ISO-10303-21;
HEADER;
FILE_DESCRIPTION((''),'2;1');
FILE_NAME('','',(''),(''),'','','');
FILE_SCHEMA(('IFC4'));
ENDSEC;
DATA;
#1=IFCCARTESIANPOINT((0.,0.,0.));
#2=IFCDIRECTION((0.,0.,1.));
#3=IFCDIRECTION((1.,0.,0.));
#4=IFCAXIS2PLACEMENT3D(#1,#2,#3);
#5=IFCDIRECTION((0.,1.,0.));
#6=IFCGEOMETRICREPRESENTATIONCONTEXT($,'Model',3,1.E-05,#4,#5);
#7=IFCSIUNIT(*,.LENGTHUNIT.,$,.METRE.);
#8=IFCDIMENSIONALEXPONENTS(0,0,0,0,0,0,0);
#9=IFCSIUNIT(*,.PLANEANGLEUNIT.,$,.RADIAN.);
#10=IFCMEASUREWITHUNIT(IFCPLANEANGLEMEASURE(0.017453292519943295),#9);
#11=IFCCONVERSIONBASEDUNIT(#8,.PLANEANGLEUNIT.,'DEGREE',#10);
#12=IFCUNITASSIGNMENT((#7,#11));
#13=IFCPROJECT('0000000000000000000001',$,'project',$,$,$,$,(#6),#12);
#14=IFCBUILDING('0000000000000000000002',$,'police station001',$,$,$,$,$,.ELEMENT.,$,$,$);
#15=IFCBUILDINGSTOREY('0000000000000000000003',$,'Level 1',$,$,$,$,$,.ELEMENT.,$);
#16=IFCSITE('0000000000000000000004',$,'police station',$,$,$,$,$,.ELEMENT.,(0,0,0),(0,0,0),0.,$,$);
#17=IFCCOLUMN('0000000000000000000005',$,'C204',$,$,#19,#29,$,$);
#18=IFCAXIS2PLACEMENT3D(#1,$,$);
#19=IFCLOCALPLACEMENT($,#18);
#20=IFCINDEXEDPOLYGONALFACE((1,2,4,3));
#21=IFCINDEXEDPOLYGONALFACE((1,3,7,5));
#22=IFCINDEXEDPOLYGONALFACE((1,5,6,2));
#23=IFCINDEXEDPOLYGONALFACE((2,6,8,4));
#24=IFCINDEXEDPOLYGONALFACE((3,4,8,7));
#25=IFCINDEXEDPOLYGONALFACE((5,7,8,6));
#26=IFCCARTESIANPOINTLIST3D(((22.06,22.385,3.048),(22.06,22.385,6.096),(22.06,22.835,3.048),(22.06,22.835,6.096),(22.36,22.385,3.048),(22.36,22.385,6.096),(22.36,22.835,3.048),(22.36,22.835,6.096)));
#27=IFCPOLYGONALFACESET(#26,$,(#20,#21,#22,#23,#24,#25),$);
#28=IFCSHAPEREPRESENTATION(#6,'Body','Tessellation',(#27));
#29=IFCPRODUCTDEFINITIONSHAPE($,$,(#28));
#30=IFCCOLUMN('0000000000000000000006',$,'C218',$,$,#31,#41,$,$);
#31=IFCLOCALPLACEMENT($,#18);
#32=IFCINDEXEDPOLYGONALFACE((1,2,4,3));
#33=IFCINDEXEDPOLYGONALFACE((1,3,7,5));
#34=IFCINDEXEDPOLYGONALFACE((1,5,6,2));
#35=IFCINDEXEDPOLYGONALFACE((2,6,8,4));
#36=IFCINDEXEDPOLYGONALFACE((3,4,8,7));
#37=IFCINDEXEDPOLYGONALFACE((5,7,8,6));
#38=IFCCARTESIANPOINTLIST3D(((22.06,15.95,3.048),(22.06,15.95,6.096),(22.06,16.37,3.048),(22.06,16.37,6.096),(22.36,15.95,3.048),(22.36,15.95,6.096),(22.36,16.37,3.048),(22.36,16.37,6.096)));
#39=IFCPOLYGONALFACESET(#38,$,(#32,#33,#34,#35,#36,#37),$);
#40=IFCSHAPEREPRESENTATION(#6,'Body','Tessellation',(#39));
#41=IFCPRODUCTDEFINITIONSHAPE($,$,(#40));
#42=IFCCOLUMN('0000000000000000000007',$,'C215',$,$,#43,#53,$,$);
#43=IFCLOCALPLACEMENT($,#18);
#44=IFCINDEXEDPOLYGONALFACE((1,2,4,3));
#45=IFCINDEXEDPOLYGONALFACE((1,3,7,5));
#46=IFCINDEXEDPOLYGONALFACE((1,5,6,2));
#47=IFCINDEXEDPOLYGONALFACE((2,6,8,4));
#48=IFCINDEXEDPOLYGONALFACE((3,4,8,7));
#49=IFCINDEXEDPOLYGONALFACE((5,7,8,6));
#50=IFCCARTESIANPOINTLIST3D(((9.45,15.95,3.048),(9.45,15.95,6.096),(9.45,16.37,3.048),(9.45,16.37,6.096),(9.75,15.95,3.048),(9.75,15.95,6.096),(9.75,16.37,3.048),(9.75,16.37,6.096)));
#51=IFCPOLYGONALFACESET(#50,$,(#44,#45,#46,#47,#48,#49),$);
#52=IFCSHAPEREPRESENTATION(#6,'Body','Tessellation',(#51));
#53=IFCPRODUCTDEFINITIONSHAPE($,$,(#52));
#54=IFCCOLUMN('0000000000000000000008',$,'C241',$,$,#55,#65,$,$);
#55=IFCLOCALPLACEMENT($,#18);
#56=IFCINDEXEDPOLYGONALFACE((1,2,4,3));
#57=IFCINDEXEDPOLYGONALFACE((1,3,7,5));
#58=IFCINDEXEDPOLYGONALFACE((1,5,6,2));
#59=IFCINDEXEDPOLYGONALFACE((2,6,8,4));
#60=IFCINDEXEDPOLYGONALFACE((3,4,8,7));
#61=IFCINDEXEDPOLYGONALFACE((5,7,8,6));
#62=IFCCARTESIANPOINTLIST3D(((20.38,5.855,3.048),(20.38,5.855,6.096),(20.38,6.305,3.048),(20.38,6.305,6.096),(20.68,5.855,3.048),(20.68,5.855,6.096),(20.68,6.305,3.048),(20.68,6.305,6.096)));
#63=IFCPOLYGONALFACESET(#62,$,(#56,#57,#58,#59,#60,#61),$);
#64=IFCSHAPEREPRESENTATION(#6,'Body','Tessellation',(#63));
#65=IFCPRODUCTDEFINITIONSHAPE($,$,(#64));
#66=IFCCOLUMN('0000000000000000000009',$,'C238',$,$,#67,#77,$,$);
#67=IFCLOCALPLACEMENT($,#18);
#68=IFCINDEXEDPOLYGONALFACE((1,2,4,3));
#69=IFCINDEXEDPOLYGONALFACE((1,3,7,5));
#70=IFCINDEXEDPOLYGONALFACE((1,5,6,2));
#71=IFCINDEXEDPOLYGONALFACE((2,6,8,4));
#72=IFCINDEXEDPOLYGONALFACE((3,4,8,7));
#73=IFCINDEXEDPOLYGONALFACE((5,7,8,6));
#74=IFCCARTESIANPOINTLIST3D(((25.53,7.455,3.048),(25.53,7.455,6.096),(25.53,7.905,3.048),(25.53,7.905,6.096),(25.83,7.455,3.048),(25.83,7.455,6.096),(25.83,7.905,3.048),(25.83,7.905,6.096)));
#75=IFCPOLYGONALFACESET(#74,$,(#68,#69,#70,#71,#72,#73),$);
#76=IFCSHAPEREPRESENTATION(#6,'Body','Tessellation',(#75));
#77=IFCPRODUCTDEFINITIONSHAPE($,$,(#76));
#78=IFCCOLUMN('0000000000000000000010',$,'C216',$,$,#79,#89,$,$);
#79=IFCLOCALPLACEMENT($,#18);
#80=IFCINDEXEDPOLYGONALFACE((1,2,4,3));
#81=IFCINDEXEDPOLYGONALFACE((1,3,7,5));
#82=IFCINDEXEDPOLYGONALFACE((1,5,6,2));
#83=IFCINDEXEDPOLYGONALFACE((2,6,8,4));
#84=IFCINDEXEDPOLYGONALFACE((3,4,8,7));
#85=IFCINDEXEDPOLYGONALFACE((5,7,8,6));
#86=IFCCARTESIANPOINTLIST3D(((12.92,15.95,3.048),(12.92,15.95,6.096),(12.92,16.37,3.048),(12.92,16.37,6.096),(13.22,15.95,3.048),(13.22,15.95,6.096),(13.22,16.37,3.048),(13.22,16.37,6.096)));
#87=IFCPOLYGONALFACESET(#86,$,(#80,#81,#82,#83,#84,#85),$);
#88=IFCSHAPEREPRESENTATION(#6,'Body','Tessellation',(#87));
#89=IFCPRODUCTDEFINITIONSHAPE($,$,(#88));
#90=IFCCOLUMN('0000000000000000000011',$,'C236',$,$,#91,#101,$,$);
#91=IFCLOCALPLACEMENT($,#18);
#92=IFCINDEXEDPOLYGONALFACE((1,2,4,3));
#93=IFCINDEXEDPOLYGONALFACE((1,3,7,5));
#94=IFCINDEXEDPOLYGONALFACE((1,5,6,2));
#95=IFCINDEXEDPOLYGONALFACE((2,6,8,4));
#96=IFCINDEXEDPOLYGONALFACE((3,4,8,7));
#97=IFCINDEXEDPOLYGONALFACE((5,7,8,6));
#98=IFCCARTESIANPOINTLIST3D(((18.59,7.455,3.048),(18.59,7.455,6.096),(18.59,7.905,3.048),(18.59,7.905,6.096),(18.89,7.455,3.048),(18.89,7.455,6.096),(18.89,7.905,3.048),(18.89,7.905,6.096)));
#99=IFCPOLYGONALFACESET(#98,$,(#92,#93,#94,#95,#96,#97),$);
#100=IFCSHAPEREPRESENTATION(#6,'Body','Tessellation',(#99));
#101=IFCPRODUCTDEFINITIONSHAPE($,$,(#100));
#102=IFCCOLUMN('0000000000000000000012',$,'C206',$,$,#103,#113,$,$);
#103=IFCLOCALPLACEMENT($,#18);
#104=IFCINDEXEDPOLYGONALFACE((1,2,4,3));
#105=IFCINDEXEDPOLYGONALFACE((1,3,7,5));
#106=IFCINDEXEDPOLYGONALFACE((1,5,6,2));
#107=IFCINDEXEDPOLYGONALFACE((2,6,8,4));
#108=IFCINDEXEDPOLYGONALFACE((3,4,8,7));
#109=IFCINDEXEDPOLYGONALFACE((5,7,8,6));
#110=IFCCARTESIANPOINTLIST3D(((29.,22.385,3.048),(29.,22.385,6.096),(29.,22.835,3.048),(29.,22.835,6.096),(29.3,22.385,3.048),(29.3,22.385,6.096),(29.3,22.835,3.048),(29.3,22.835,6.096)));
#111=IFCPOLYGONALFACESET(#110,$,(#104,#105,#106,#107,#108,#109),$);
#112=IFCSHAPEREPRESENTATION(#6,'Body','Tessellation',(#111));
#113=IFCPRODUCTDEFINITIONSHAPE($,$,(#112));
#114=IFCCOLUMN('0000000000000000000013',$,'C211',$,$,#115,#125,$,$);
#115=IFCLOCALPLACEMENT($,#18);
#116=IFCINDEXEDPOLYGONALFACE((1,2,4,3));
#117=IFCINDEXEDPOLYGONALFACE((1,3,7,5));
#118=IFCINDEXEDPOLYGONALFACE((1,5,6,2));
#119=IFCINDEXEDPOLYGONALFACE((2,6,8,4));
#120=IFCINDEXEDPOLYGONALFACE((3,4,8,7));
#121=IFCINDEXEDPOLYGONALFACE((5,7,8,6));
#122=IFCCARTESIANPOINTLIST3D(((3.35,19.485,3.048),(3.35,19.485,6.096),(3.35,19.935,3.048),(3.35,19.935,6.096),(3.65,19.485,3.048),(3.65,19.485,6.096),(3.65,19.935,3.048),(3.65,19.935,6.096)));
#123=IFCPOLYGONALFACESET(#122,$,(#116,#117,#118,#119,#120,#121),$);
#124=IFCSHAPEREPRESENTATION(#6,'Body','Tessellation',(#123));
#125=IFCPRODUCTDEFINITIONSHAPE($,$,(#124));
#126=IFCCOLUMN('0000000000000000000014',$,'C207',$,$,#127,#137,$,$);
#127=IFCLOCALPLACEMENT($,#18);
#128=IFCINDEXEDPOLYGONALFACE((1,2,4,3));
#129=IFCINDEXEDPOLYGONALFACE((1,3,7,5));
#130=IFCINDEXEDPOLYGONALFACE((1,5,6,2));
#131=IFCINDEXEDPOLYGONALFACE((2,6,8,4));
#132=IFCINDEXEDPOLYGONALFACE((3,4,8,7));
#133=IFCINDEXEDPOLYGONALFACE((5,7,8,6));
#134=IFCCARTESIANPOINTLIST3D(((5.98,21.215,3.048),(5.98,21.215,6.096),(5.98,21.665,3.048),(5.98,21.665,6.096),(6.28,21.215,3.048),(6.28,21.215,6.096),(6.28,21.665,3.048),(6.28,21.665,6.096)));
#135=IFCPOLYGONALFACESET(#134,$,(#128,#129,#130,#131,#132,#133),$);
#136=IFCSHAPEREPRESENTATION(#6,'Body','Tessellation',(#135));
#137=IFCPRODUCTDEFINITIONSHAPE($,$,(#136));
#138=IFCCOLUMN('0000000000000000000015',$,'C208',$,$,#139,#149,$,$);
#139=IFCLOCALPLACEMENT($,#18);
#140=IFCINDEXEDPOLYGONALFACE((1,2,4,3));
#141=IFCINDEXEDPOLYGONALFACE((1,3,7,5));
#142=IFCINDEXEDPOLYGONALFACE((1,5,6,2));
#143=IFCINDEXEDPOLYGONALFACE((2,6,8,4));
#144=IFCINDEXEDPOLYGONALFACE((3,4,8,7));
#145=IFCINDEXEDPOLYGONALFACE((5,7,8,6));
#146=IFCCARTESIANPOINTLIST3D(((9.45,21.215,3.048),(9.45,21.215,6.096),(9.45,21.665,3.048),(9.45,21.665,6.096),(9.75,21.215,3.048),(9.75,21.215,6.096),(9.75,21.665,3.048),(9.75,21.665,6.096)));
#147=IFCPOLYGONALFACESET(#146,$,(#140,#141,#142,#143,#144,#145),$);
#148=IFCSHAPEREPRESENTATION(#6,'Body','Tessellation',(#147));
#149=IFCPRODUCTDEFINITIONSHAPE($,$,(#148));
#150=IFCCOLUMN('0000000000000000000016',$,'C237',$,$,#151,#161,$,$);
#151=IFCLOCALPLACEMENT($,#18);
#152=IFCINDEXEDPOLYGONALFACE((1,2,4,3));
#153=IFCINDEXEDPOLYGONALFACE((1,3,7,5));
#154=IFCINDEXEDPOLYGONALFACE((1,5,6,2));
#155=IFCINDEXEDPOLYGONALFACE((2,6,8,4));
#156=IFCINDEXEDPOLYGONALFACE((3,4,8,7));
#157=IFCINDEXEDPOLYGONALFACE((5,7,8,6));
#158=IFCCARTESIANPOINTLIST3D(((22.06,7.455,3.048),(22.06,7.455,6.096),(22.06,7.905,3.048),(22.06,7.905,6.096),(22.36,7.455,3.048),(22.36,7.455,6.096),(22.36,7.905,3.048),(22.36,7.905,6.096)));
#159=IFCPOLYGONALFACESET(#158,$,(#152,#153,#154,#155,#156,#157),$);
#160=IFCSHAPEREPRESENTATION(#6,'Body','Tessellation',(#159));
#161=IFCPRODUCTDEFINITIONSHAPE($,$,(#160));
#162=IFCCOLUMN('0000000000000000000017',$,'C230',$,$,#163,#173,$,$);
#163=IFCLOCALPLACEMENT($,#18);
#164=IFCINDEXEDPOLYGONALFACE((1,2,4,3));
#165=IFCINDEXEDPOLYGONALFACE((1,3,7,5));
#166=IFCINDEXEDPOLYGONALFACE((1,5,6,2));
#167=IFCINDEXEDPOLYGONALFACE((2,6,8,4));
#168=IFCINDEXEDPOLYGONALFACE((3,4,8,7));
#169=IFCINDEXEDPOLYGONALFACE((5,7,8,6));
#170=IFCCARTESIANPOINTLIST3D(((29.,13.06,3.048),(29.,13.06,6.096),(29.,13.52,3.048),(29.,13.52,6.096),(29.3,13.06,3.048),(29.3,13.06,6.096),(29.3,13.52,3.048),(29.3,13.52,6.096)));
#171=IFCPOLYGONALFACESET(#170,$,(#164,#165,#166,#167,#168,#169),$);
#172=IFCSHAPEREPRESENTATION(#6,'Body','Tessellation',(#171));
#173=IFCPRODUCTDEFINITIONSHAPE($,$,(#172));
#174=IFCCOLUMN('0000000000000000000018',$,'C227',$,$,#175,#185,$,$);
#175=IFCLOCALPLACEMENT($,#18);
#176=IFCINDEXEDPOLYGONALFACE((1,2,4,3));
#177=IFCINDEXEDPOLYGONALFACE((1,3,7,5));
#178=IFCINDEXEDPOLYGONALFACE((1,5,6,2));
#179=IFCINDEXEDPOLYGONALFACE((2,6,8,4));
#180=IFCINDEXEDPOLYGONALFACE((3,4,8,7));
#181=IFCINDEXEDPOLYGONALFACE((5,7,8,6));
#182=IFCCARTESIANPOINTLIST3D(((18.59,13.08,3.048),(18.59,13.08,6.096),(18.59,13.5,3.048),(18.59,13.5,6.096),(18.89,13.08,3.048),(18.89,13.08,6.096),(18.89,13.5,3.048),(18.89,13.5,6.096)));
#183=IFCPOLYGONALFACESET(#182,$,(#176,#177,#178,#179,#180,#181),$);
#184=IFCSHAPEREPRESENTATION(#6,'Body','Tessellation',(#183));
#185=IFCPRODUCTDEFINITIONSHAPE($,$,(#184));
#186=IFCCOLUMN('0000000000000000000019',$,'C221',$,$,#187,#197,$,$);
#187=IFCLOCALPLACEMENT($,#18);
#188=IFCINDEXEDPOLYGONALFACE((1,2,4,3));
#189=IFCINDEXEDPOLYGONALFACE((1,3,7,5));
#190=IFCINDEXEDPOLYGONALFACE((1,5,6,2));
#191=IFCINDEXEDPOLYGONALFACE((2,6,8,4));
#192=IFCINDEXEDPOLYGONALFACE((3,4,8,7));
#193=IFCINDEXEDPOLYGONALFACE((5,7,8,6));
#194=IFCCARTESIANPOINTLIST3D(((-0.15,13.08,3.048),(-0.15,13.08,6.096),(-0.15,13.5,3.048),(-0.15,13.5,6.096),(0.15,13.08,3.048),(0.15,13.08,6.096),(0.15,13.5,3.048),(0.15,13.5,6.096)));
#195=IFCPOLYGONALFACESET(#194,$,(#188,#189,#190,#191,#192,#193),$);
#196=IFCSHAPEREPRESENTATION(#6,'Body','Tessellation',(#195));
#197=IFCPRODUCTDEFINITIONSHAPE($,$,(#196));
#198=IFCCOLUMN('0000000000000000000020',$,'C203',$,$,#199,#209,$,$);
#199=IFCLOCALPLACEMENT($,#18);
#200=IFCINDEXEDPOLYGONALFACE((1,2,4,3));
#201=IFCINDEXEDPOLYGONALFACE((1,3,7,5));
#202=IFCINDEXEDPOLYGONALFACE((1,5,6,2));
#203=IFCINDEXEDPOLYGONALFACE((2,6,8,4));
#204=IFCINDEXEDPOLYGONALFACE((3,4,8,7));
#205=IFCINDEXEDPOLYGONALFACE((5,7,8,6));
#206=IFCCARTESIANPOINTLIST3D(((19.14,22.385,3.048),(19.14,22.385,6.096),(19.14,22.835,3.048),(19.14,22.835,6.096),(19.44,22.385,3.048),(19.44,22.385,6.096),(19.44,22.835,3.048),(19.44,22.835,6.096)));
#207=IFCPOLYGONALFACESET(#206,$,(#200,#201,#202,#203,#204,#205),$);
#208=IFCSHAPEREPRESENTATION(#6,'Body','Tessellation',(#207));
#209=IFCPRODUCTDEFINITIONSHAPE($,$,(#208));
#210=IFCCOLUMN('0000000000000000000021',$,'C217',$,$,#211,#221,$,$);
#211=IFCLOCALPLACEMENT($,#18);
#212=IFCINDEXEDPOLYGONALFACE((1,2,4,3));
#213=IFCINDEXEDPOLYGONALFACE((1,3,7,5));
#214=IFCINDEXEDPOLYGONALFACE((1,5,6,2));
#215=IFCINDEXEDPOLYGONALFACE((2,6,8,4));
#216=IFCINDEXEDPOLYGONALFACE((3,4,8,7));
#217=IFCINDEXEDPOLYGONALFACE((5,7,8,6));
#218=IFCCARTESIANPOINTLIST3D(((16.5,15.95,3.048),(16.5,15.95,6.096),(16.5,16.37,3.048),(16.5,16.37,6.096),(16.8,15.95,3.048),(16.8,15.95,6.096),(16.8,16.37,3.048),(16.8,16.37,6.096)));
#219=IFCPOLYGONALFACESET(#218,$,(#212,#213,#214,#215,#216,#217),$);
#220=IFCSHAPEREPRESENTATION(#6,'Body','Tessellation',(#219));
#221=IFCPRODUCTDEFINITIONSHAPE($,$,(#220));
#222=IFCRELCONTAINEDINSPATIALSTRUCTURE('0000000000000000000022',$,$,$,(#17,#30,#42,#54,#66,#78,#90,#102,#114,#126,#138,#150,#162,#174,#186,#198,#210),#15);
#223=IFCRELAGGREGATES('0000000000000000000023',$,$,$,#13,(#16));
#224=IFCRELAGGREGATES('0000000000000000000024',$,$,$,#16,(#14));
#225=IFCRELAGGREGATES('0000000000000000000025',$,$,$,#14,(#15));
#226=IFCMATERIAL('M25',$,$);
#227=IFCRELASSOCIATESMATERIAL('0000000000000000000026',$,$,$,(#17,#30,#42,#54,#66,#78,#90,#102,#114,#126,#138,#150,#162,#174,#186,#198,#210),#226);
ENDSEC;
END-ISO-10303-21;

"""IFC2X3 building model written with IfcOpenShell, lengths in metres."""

from ifc_helpers import new_model, entity, si_unit, converted_unit, direction, frame, frame_2d, origin_with_axes, place, context, project, spatial, rectangle, extrude, material, element, save


model = new_model("IFC2X3")

# Units and contexts
model_context = context("Model", 3, precision=1e-05, world=origin_with_axes(), true_north=direction((0.0, 1.0, 0.0)))
ifc_project = project(units=[si_unit("LENGTHUNIT", "METRE"), converted_unit("PLANEANGLEUNIT", "DEGREE", entity("IfcPlaneAngleMeasure", 0.017453292519943295), si_unit("PLANEANGLEUNIT", "RADIAN"), dimensions=[0, 0, 0, 0, 0, 0, 0])], contexts=[model_context])

# Site, building, storey
site = spatial("IfcSite", under=ifc_project, Name="police station", CompositionType="ELEMENT", RefLatitude=(0, 0, 0), RefLongitude=(0, 0, 0), RefElevation=0.0)
building = spatial("IfcBuilding", under=site, Name="police station001", CompositionType="ELEMENT")
storey = spatial("IfcBuildingStorey", under=building, Name="Level 1", CompositionType="ELEMENT")

# Columns
ifc_material = material(Name="M25")
placement = place(None, origin_with_axes())
element("IfcColumn", 1, at=placement, inside=storey, material=ifc_material, Name="C204", context=model_context, shape_type="SweptSolid", body=[
    extrude(rectangle(XDim=0.3, YDim=0.45, at=frame_2d((0.0, 0.0), x_axis=(1.0, 0.0, 0.0))), frame((22.21, 22.61, 3.048), z_axis=(0.0, 0.0, 1.0), x_axis=(1.0, 0.0, 0.0)), (0.0, 0.0, 1.0), 3.048),
])
element("IfcColumn", 2, at=placement, inside=storey, material=ifc_material, Name="C218", context=model_context, shape_type="SweptSolid", body=[
    extrude(rectangle(XDim=0.3, YDim=0.42, at=frame_2d((0.0, 0.0), x_axis=(1.0, 0.0, 0.0))), frame((22.21, 16.16, 3.048), z_axis=(0.0, 0.0, 1.0), x_axis=(1.0, 0.0, 0.0)), (0.0, 0.0, 1.0), 3.048),
])
element("IfcColumn", 3, at=placement, inside=storey, material=ifc_material, Name="C215", context=model_context, shape_type="SweptSolid", body=[
    extrude(rectangle(XDim=0.3, YDim=0.42, at=frame_2d((0.0, 0.0), x_axis=(1.0, 0.0, 0.0))), frame((9.6, 16.16, 3.048), z_axis=(0.0, 0.0, 1.0), x_axis=(1.0, 0.0, 0.0)), (0.0, 0.0, 1.0), 3.048),
])
element("IfcColumn", 4, at=placement, inside=storey, material=ifc_material, Name="C241", context=model_context, shape_type="SweptSolid", body=[
    extrude(rectangle(XDim=0.3, YDim=0.45, at=frame_2d((0.0, 0.0), x_axis=(1.0, 0.0, 0.0))), frame((20.53, 6.08, 3.048), z_axis=(0.0, 0.0, 1.0), x_axis=(1.0, 0.0, 0.0)), (0.0, 0.0, 1.0), 3.048),
])
element("IfcColumn", 5, at=placement, inside=storey, material=ifc_material, Name="C238", context=model_context, shape_type="SweptSolid", body=[
    extrude(rectangle(XDim=0.3, YDim=0.45, at=frame_2d((0.0, 0.0), x_axis=(1.0, 0.0, 0.0))), frame((25.68, 7.68, 3.048), z_axis=(0.0, 0.0, 1.0), x_axis=(1.0, 0.0, 0.0)), (0.0, 0.0, 1.0), 3.048),
])
element("IfcColumn", 6, at=placement, inside=storey, material=ifc_material, Name="C216", context=model_context, shape_type="SweptSolid", body=[
    extrude(rectangle(XDim=0.3, YDim=0.42, at=frame_2d((0.0, 0.0), x_axis=(1.0, 0.0, 0.0))), frame((13.07, 16.16, 3.048), z_axis=(0.0, 0.0, 1.0), x_axis=(1.0, 0.0, 0.0)), (0.0, 0.0, 1.0), 3.048),
])
element("IfcColumn", 7, at=placement, inside=storey, material=ifc_material, Name="C236", context=model_context, shape_type="SweptSolid", body=[
    extrude(rectangle(XDim=0.3, YDim=0.45, at=frame_2d((0.0, 0.0), x_axis=(1.0, 0.0, 0.0))), frame((18.74, 7.68, 3.048), z_axis=(0.0, 0.0, 1.0), x_axis=(1.0, 0.0, 0.0)), (0.0, 0.0, 1.0), 3.048),
])
element("IfcColumn", 8, at=placement, inside=storey, material=ifc_material, Name="C206", context=model_context, shape_type="SweptSolid", body=[
    extrude(rectangle(XDim=0.3, YDim=0.45, at=frame_2d((0.0, 0.0), x_axis=(1.0, 0.0, 0.0))), frame((29.15, 22.61, 3.048), z_axis=(0.0, 0.0, 1.0), x_axis=(1.0, 0.0, 0.0)), (0.0, 0.0, 1.0), 3.048),
])
element("IfcColumn", 9, at=placement, inside=storey, material=ifc_material, Name="C211", context=model_context, shape_type="SweptSolid", body=[
    extrude(rectangle(XDim=0.3, YDim=0.45, at=frame_2d((0.0, 0.0), x_axis=(1.0, 0.0, 0.0))), frame((3.5, 19.71, 3.048), z_axis=(0.0, 0.0, 1.0), x_axis=(1.0, 0.0, 0.0)), (0.0, 0.0, 1.0), 3.048),
])
element("IfcColumn", 10, at=placement, inside=storey, material=ifc_material, Name="C207", context=model_context, shape_type="SweptSolid", body=[
    extrude(rectangle(XDim=0.3, YDim=0.45, at=frame_2d((0.0, 0.0), x_axis=(1.0, 0.0, 0.0))), frame((6.13, 21.44, 3.048), z_axis=(0.0, 0.0, 1.0), x_axis=(1.0, 0.0, 0.0)), (0.0, 0.0, 1.0), 3.048),
])
element("IfcColumn", 11, at=placement, inside=storey, material=ifc_material, Name="C208", context=model_context, shape_type="SweptSolid", body=[
    extrude(rectangle(XDim=0.3, YDim=0.45, at=frame_2d((0.0, 0.0), x_axis=(1.0, 0.0, 0.0))), frame((9.6, 21.44, 3.048), z_axis=(0.0, 0.0, 1.0), x_axis=(1.0, 0.0, 0.0)), (0.0, 0.0, 1.0), 3.048),
])
element("IfcColumn", 12, at=placement, inside=storey, material=ifc_material, Name="C237", context=model_context, shape_type="SweptSolid", body=[
    extrude(rectangle(XDim=0.3, YDim=0.45, at=frame_2d((0.0, 0.0), x_axis=(1.0, 0.0, 0.0))), frame((22.21, 7.68, 3.048), z_axis=(0.0, 0.0, 1.0), x_axis=(1.0, 0.0, 0.0)), (0.0, 0.0, 1.0), 3.048),
])
element("IfcColumn", 13, at=placement, inside=storey, material=ifc_material, Name="C230", context=model_context, shape_type="SweptSolid", body=[
    extrude(rectangle(XDim=0.3, YDim=0.46, at=frame_2d((0.0, 0.0), x_axis=(1.0, 0.0, 0.0))), frame((29.15, 13.29, 3.048), z_axis=(0.0, 0.0, 1.0), x_axis=(1.0, 0.0, 0.0)), (0.0, 0.0, 1.0), 3.048),
])
element("IfcColumn", 14, at=placement, inside=storey, material=ifc_material, Name="C227", context=model_context, shape_type="SweptSolid", body=[
    extrude(rectangle(XDim=0.3, YDim=0.42, at=frame_2d((0.0, 0.0), x_axis=(1.0, 0.0, 0.0))), frame((18.74, 13.29, 3.048), z_axis=(0.0, 0.0, 1.0), x_axis=(1.0, 0.0, 0.0)), (0.0, 0.0, 1.0), 3.048),
])
element("IfcColumn", 15, at=placement, inside=storey, material=ifc_material, Name="C221", context=model_context, shape_type="SweptSolid", body=[
    extrude(rectangle(XDim=0.3, YDim=0.42, at=frame_2d((0.0, 0.0), x_axis=(1.0, 0.0, 0.0))), frame((0.0, 13.29, 3.048), z_axis=(0.0, 0.0, 1.0), x_axis=(1.0, 0.0, 0.0)), (0.0, 0.0, 1.0), 3.048),
])
element("IfcColumn", 16, at=placement, inside=storey, material=ifc_material, Name="C203", context=model_context, shape_type="SweptSolid", body=[
    extrude(rectangle(XDim=0.3, YDim=0.45, at=frame_2d((0.0, 0.0), x_axis=(1.0, 0.0, 0.0))), frame((19.29, 22.61, 3.048), z_axis=(0.0, 0.0, 1.0), x_axis=(1.0, 0.0, 0.0)), (0.0, 0.0, 1.0), 3.048),
])
element("IfcColumn", 17, at=placement, inside=storey, material=ifc_material, Name="C217", context=model_context, shape_type="SweptSolid", body=[
    extrude(rectangle(XDim=0.3, YDim=0.42, at=frame_2d((0.0, 0.0), x_axis=(1.0, 0.0, 0.0))), frame((16.65, 16.16, 3.048), z_axis=(0.0, 0.0, 1.0), x_axis=(1.0, 0.0, 0.0)), (0.0, 0.0, 1.0), 3.048),
])

save(model, "model.ifc")
